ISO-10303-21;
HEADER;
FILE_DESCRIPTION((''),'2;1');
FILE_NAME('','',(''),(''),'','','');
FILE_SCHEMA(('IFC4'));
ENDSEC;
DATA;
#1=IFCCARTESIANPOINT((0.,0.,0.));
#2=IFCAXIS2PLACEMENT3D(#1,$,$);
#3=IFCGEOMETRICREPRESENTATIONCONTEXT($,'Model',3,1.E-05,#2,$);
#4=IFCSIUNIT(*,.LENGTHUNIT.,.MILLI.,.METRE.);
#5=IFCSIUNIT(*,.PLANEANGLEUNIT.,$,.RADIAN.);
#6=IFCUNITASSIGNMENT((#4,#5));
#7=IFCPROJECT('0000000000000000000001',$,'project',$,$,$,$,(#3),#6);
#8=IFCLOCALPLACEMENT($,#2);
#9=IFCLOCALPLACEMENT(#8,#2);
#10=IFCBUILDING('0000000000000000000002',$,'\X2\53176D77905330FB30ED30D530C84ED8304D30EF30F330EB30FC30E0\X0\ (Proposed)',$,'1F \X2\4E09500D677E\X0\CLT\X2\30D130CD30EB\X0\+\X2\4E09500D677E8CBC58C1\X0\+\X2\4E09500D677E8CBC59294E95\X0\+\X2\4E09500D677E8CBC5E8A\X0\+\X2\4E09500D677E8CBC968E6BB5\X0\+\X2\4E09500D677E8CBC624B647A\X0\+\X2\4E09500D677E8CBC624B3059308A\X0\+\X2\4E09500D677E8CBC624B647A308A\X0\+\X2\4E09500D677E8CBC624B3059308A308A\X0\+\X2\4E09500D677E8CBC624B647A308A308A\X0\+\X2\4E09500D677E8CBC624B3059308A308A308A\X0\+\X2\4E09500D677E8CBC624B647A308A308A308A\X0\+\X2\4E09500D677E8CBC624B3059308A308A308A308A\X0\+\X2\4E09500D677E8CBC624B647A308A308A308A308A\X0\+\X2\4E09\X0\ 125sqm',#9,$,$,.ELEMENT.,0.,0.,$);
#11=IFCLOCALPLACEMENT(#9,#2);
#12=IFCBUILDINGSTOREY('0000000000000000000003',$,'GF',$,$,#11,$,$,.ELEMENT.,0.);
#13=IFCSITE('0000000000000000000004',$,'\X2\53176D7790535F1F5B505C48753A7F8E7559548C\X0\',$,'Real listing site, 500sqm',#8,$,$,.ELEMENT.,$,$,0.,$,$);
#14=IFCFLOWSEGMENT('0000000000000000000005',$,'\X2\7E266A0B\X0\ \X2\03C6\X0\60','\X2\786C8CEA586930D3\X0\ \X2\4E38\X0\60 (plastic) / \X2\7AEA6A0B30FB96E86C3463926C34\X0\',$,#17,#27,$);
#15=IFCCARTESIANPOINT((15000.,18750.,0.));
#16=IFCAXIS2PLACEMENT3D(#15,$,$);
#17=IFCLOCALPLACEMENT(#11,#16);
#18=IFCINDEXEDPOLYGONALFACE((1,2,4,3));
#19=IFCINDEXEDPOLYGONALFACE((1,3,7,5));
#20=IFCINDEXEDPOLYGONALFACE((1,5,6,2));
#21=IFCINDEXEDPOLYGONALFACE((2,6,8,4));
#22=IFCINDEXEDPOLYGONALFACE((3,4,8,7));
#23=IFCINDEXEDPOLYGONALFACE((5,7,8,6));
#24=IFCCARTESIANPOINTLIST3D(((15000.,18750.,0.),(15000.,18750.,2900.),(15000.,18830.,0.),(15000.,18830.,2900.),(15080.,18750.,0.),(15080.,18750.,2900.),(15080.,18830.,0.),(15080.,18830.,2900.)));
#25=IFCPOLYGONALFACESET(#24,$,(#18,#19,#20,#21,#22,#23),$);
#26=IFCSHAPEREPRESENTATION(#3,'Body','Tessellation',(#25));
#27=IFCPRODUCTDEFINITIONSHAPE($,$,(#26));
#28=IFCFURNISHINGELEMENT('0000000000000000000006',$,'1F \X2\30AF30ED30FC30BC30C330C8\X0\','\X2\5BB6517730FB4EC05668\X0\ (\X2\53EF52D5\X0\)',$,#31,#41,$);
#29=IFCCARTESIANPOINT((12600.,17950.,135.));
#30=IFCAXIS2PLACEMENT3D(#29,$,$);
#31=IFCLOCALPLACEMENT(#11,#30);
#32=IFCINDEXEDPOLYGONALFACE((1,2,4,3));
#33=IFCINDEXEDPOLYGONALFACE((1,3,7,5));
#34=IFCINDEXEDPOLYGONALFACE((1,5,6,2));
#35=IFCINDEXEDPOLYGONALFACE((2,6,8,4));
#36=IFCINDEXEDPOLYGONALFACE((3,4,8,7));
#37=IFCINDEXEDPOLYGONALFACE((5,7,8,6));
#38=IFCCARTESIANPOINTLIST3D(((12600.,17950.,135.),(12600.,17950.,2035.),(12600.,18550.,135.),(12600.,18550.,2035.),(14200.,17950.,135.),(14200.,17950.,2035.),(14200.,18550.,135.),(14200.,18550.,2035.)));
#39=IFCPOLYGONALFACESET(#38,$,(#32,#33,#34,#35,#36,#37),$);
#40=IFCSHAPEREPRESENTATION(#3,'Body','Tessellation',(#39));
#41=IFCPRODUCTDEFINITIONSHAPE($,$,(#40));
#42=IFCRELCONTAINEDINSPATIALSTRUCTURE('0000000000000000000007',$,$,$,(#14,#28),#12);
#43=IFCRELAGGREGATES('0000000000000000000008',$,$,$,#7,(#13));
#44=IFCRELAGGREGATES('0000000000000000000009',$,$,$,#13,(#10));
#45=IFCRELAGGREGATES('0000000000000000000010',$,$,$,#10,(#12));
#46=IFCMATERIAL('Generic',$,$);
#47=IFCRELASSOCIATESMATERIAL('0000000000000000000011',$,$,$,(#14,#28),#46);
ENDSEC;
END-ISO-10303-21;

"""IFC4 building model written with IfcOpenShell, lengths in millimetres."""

from ifc_helpers import new_model, si_unit, frame, frame_2d, origin, place, context, project, spatial, rectangle, extrude, material, element, save


model = new_model("IFC4")

# Units and contexts
model_context = context("Model", 3, precision=1e-05, world=origin())
ifc_project = project(units=[si_unit("LENGTHUNIT", "METRE", prefix="MILLI"), si_unit("PLANEANGLEUNIT", "RADIAN")], contexts=[model_context])

# Site, building, storey
site_placement = place(None, origin())
site = spatial("IfcSite", under=ifc_project, at=site_placement, Name="北海道弟子屈町美留和", ObjectType="Real listing site, 500sqm", CompositionType="ELEMENT", RefElevation=0.0)
building_placement = place(site_placement, origin())
building = spatial("IfcBuilding", under=site, at=building_placement, Name="北海道・ロフト付きワンルーム (Proposed)", ObjectType="1F 三倍松CLTパネル+三倍松貼壁+三倍松貼天井+三倍松貼床+三倍松貼階段+三倍松貼手摺+三倍松貼手すり+三倍松貼手摺り+三倍松貼手すりり+三倍松貼手摺りり+三倍松貼手すりりり+三倍松貼手摺りりり+三倍松貼手すりりりり+三倍松貼手摺りりりり+三 125sqm", CompositionType="ELEMENT", ElevationOfRefHeight=0.0, ElevationOfTerrain=0.0)
storey_placement = place(building_placement, origin())
storey = spatial("IfcBuildingStorey", under=building, at=storey_placement, Name="GF", CompositionType="ELEMENT", Elevation=0.0)

# Shared definitions
ifc_material_1 = material(Name="Generic")

# Flow segment
flow_segment_placement = place(storey_placement, frame((15000.0, 18750.0, 0.0)))
element("IfcFlowSegment", 1, at=flow_segment_placement, inside=storey, material=ifc_material_1, Name="縦樋 φ60", Description="硬質塩ビ 丸60 (plastic) / 竪樋・雨水排水", context=model_context, shape_type="SweptSolid", body=[
    extrude(rectangle(XDim=80.0, YDim=80.0, at=frame_2d((40.0, 40.0))), frame((15000.0, 18750.0, 0.0)), (0.0, 0.0, 1.0), 2900.0),
])

# Furnishing element
furnishing_placement = place(storey_placement, frame((12600.0, 17950.0, 135.0)))
element("IfcFurnishingElement", 2, at=furnishing_placement, inside=storey, material=ifc_material_1, Name="1F クローゼット", Description="家具・什器 (可動)", context=model_context, shape_type="SweptSolid", body=[
    extrude(rectangle(XDim=1600.0, YDim=600.0, at=frame_2d((800.0, 300.0))), frame((12600.0, 17950.0, 135.0)), (0.0, 0.0, 1.0), 1900.0),
])

save(model, "model.ifc")
